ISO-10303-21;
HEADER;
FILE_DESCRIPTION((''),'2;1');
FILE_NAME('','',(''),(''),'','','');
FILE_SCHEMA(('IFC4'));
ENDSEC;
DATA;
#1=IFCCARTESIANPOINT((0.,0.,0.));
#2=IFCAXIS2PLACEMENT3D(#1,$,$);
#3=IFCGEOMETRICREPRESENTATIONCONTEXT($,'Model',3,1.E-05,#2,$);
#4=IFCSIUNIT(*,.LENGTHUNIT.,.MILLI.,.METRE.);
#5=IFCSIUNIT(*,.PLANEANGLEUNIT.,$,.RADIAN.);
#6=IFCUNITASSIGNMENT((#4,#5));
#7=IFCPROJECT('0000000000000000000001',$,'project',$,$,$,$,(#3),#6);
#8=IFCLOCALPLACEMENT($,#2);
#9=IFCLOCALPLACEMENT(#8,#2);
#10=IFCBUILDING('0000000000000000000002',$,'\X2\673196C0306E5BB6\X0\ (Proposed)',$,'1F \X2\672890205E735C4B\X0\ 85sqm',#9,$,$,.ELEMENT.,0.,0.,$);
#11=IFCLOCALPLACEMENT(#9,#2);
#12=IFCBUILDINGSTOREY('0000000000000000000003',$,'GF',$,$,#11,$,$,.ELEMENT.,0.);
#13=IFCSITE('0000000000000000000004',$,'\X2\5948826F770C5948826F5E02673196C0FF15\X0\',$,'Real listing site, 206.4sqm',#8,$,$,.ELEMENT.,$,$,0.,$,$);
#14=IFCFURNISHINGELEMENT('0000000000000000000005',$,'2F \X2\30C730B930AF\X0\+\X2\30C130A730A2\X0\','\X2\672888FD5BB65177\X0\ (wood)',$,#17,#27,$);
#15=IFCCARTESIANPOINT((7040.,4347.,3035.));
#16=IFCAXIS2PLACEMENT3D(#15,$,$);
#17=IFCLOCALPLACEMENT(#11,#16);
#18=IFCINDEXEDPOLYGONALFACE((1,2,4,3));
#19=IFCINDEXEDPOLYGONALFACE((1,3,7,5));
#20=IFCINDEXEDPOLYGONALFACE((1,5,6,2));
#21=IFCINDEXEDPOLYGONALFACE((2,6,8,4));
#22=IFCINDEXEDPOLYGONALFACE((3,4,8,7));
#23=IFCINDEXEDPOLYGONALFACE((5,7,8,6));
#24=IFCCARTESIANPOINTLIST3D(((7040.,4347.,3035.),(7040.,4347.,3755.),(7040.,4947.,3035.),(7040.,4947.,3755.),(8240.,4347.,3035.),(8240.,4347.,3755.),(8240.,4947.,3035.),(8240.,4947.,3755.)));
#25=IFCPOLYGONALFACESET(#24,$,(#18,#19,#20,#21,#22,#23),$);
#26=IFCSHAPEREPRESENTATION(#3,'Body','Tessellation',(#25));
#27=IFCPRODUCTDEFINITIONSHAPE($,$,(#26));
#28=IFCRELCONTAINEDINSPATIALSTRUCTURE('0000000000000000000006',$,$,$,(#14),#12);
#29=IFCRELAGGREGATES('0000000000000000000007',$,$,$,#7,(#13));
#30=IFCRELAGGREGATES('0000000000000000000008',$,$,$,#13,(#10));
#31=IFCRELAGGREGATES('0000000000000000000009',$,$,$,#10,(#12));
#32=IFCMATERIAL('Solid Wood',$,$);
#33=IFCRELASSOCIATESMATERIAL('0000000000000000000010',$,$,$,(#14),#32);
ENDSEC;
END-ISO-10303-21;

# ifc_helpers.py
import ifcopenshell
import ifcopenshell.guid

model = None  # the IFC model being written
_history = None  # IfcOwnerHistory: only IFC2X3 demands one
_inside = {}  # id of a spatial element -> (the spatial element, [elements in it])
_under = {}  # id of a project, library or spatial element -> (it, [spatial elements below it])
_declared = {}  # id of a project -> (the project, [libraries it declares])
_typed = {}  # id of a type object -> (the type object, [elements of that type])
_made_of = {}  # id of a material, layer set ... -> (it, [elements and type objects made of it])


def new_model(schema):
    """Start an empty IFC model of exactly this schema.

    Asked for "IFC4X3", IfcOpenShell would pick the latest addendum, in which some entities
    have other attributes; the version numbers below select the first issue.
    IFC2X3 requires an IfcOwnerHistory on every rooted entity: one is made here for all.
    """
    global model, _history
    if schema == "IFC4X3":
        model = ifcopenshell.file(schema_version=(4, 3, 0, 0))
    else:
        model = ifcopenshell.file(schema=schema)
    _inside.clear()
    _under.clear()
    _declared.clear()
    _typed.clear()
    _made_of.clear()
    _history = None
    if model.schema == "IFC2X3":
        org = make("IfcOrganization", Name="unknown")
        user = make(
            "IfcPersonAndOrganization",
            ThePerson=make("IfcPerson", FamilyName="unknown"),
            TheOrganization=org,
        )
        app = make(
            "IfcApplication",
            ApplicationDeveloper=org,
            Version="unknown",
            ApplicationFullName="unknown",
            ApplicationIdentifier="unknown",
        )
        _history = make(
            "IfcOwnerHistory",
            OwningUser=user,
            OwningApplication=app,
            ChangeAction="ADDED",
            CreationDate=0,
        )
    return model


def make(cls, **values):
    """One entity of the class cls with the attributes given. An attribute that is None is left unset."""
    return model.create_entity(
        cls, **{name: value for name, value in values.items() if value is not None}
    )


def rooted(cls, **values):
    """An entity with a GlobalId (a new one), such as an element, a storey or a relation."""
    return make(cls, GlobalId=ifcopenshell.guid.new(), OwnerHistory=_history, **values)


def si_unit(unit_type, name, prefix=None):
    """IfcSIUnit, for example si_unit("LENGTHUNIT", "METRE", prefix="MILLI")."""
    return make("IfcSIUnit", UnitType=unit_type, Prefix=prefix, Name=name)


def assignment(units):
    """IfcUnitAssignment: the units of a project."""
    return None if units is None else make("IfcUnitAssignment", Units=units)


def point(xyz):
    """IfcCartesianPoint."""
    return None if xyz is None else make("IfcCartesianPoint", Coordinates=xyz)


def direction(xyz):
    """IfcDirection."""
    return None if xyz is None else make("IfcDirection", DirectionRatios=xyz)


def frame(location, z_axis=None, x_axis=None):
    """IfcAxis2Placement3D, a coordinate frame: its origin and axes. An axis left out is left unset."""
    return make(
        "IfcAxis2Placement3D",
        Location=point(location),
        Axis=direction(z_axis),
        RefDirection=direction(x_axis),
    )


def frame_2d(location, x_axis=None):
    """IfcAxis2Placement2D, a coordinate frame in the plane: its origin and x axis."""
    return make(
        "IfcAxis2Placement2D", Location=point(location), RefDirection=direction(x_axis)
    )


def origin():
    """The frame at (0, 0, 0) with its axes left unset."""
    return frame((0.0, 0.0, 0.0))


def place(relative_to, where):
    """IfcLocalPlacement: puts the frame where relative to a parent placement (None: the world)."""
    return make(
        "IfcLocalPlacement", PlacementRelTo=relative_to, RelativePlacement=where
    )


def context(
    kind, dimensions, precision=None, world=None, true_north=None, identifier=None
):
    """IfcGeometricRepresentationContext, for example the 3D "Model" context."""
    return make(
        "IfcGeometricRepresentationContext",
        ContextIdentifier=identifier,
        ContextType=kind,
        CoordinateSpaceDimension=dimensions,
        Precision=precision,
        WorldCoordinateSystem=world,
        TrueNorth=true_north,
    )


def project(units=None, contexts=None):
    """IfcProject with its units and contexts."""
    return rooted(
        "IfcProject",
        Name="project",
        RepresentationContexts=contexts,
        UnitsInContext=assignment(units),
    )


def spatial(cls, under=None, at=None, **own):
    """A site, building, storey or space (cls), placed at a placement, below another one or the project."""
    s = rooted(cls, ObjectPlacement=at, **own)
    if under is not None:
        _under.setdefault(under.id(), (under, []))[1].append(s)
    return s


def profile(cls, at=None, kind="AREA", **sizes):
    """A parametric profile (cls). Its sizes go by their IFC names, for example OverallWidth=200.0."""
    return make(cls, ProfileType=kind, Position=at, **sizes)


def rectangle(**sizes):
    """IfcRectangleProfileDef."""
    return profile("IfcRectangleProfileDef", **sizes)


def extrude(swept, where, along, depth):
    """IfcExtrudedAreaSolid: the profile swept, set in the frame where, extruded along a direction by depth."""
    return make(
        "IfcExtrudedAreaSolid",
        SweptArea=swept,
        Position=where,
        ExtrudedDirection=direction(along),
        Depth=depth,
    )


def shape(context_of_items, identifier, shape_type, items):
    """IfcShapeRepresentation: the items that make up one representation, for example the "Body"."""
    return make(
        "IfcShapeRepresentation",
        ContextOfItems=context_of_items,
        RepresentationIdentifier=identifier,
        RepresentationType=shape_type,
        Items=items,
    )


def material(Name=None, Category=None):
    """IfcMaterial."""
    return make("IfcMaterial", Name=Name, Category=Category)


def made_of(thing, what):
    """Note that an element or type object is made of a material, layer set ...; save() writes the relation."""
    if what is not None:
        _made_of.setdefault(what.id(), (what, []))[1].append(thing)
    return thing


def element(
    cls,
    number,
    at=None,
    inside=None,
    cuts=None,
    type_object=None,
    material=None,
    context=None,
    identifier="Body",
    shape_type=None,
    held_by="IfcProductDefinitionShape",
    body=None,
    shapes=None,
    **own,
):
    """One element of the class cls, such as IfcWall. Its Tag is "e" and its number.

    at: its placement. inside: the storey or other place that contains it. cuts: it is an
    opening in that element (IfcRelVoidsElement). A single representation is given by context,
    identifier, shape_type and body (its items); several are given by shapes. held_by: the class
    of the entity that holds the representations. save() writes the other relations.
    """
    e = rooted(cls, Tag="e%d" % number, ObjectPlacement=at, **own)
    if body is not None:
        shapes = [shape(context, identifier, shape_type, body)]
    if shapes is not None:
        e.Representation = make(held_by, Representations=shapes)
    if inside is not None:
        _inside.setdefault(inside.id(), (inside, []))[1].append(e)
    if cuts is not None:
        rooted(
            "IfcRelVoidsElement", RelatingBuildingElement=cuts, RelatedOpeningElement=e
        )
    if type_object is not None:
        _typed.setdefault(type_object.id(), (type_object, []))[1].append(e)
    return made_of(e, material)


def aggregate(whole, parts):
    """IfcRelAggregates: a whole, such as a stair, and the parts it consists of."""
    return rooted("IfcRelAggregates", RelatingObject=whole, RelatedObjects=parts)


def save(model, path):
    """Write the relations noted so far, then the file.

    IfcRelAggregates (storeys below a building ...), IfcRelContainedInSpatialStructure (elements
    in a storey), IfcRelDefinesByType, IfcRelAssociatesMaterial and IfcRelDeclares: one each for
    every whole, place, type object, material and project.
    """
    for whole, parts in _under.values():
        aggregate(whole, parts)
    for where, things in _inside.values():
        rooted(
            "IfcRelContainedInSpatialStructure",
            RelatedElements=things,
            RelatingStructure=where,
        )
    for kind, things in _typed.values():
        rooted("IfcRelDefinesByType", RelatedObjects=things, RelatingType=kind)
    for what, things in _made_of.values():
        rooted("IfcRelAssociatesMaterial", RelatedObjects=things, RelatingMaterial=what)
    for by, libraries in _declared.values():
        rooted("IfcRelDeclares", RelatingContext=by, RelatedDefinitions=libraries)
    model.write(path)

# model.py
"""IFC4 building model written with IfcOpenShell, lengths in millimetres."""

from ifc_helpers import new_model, si_unit, frame, frame_2d, origin, place, context, project, spatial, rectangle, extrude, material, element, save


model = new_model("IFC4")

# Units and contexts
model_context = context("Model", 3, precision=1e-05, world=origin())
ifc_project = project(units=[si_unit("LENGTHUNIT", "METRE", prefix="MILLI"), si_unit("PLANEANGLEUNIT", "RADIAN")], contexts=[model_context])

# Site, building, storey
site_placement = place(None, origin())
site = spatial("IfcSite", under=ifc_project, at=site_placement, Name="奈良県奈良市朱雀５", ObjectType="Real listing site, 206.4sqm", CompositionType="ELEMENT", RefElevation=0.0)
building_placement = place(site_placement, origin())
building = spatial("IfcBuilding", under=site, at=building_placement, Name="朱雀の家 (Proposed)", ObjectType="1F 木造平屋 85sqm", CompositionType="ELEMENT", ElevationOfRefHeight=0.0, ElevationOfTerrain=0.0)
storey_placement = place(building_placement, origin())
storey = spatial("IfcBuildingStorey", under=building, at=storey_placement, Name="GF", CompositionType="ELEMENT", Elevation=0.0)

# Shared definitions
ifc_material_1 = material(Name="Solid Wood")

# Furnishing element
furnishing_1_placement = place(storey_placement, frame((7040.0, 4347.0, 3035.0)))
element("IfcFurnishingElement", 1, at=furnishing_1_placement, inside=storey, material=ifc_material_1, Name="2F デスク+チェア", Description="木製家具 (wood)", context=model_context, shape_type="SweptSolid", body=[
    extrude(rectangle(XDim=1200.0, YDim=600.0, at=frame_2d((600.0, 300.0))), frame((7040.0, 4347.0, 3035.0)), (0.0, 0.0, 1.0), 720.0),
])

save(model, "model.ifc")
